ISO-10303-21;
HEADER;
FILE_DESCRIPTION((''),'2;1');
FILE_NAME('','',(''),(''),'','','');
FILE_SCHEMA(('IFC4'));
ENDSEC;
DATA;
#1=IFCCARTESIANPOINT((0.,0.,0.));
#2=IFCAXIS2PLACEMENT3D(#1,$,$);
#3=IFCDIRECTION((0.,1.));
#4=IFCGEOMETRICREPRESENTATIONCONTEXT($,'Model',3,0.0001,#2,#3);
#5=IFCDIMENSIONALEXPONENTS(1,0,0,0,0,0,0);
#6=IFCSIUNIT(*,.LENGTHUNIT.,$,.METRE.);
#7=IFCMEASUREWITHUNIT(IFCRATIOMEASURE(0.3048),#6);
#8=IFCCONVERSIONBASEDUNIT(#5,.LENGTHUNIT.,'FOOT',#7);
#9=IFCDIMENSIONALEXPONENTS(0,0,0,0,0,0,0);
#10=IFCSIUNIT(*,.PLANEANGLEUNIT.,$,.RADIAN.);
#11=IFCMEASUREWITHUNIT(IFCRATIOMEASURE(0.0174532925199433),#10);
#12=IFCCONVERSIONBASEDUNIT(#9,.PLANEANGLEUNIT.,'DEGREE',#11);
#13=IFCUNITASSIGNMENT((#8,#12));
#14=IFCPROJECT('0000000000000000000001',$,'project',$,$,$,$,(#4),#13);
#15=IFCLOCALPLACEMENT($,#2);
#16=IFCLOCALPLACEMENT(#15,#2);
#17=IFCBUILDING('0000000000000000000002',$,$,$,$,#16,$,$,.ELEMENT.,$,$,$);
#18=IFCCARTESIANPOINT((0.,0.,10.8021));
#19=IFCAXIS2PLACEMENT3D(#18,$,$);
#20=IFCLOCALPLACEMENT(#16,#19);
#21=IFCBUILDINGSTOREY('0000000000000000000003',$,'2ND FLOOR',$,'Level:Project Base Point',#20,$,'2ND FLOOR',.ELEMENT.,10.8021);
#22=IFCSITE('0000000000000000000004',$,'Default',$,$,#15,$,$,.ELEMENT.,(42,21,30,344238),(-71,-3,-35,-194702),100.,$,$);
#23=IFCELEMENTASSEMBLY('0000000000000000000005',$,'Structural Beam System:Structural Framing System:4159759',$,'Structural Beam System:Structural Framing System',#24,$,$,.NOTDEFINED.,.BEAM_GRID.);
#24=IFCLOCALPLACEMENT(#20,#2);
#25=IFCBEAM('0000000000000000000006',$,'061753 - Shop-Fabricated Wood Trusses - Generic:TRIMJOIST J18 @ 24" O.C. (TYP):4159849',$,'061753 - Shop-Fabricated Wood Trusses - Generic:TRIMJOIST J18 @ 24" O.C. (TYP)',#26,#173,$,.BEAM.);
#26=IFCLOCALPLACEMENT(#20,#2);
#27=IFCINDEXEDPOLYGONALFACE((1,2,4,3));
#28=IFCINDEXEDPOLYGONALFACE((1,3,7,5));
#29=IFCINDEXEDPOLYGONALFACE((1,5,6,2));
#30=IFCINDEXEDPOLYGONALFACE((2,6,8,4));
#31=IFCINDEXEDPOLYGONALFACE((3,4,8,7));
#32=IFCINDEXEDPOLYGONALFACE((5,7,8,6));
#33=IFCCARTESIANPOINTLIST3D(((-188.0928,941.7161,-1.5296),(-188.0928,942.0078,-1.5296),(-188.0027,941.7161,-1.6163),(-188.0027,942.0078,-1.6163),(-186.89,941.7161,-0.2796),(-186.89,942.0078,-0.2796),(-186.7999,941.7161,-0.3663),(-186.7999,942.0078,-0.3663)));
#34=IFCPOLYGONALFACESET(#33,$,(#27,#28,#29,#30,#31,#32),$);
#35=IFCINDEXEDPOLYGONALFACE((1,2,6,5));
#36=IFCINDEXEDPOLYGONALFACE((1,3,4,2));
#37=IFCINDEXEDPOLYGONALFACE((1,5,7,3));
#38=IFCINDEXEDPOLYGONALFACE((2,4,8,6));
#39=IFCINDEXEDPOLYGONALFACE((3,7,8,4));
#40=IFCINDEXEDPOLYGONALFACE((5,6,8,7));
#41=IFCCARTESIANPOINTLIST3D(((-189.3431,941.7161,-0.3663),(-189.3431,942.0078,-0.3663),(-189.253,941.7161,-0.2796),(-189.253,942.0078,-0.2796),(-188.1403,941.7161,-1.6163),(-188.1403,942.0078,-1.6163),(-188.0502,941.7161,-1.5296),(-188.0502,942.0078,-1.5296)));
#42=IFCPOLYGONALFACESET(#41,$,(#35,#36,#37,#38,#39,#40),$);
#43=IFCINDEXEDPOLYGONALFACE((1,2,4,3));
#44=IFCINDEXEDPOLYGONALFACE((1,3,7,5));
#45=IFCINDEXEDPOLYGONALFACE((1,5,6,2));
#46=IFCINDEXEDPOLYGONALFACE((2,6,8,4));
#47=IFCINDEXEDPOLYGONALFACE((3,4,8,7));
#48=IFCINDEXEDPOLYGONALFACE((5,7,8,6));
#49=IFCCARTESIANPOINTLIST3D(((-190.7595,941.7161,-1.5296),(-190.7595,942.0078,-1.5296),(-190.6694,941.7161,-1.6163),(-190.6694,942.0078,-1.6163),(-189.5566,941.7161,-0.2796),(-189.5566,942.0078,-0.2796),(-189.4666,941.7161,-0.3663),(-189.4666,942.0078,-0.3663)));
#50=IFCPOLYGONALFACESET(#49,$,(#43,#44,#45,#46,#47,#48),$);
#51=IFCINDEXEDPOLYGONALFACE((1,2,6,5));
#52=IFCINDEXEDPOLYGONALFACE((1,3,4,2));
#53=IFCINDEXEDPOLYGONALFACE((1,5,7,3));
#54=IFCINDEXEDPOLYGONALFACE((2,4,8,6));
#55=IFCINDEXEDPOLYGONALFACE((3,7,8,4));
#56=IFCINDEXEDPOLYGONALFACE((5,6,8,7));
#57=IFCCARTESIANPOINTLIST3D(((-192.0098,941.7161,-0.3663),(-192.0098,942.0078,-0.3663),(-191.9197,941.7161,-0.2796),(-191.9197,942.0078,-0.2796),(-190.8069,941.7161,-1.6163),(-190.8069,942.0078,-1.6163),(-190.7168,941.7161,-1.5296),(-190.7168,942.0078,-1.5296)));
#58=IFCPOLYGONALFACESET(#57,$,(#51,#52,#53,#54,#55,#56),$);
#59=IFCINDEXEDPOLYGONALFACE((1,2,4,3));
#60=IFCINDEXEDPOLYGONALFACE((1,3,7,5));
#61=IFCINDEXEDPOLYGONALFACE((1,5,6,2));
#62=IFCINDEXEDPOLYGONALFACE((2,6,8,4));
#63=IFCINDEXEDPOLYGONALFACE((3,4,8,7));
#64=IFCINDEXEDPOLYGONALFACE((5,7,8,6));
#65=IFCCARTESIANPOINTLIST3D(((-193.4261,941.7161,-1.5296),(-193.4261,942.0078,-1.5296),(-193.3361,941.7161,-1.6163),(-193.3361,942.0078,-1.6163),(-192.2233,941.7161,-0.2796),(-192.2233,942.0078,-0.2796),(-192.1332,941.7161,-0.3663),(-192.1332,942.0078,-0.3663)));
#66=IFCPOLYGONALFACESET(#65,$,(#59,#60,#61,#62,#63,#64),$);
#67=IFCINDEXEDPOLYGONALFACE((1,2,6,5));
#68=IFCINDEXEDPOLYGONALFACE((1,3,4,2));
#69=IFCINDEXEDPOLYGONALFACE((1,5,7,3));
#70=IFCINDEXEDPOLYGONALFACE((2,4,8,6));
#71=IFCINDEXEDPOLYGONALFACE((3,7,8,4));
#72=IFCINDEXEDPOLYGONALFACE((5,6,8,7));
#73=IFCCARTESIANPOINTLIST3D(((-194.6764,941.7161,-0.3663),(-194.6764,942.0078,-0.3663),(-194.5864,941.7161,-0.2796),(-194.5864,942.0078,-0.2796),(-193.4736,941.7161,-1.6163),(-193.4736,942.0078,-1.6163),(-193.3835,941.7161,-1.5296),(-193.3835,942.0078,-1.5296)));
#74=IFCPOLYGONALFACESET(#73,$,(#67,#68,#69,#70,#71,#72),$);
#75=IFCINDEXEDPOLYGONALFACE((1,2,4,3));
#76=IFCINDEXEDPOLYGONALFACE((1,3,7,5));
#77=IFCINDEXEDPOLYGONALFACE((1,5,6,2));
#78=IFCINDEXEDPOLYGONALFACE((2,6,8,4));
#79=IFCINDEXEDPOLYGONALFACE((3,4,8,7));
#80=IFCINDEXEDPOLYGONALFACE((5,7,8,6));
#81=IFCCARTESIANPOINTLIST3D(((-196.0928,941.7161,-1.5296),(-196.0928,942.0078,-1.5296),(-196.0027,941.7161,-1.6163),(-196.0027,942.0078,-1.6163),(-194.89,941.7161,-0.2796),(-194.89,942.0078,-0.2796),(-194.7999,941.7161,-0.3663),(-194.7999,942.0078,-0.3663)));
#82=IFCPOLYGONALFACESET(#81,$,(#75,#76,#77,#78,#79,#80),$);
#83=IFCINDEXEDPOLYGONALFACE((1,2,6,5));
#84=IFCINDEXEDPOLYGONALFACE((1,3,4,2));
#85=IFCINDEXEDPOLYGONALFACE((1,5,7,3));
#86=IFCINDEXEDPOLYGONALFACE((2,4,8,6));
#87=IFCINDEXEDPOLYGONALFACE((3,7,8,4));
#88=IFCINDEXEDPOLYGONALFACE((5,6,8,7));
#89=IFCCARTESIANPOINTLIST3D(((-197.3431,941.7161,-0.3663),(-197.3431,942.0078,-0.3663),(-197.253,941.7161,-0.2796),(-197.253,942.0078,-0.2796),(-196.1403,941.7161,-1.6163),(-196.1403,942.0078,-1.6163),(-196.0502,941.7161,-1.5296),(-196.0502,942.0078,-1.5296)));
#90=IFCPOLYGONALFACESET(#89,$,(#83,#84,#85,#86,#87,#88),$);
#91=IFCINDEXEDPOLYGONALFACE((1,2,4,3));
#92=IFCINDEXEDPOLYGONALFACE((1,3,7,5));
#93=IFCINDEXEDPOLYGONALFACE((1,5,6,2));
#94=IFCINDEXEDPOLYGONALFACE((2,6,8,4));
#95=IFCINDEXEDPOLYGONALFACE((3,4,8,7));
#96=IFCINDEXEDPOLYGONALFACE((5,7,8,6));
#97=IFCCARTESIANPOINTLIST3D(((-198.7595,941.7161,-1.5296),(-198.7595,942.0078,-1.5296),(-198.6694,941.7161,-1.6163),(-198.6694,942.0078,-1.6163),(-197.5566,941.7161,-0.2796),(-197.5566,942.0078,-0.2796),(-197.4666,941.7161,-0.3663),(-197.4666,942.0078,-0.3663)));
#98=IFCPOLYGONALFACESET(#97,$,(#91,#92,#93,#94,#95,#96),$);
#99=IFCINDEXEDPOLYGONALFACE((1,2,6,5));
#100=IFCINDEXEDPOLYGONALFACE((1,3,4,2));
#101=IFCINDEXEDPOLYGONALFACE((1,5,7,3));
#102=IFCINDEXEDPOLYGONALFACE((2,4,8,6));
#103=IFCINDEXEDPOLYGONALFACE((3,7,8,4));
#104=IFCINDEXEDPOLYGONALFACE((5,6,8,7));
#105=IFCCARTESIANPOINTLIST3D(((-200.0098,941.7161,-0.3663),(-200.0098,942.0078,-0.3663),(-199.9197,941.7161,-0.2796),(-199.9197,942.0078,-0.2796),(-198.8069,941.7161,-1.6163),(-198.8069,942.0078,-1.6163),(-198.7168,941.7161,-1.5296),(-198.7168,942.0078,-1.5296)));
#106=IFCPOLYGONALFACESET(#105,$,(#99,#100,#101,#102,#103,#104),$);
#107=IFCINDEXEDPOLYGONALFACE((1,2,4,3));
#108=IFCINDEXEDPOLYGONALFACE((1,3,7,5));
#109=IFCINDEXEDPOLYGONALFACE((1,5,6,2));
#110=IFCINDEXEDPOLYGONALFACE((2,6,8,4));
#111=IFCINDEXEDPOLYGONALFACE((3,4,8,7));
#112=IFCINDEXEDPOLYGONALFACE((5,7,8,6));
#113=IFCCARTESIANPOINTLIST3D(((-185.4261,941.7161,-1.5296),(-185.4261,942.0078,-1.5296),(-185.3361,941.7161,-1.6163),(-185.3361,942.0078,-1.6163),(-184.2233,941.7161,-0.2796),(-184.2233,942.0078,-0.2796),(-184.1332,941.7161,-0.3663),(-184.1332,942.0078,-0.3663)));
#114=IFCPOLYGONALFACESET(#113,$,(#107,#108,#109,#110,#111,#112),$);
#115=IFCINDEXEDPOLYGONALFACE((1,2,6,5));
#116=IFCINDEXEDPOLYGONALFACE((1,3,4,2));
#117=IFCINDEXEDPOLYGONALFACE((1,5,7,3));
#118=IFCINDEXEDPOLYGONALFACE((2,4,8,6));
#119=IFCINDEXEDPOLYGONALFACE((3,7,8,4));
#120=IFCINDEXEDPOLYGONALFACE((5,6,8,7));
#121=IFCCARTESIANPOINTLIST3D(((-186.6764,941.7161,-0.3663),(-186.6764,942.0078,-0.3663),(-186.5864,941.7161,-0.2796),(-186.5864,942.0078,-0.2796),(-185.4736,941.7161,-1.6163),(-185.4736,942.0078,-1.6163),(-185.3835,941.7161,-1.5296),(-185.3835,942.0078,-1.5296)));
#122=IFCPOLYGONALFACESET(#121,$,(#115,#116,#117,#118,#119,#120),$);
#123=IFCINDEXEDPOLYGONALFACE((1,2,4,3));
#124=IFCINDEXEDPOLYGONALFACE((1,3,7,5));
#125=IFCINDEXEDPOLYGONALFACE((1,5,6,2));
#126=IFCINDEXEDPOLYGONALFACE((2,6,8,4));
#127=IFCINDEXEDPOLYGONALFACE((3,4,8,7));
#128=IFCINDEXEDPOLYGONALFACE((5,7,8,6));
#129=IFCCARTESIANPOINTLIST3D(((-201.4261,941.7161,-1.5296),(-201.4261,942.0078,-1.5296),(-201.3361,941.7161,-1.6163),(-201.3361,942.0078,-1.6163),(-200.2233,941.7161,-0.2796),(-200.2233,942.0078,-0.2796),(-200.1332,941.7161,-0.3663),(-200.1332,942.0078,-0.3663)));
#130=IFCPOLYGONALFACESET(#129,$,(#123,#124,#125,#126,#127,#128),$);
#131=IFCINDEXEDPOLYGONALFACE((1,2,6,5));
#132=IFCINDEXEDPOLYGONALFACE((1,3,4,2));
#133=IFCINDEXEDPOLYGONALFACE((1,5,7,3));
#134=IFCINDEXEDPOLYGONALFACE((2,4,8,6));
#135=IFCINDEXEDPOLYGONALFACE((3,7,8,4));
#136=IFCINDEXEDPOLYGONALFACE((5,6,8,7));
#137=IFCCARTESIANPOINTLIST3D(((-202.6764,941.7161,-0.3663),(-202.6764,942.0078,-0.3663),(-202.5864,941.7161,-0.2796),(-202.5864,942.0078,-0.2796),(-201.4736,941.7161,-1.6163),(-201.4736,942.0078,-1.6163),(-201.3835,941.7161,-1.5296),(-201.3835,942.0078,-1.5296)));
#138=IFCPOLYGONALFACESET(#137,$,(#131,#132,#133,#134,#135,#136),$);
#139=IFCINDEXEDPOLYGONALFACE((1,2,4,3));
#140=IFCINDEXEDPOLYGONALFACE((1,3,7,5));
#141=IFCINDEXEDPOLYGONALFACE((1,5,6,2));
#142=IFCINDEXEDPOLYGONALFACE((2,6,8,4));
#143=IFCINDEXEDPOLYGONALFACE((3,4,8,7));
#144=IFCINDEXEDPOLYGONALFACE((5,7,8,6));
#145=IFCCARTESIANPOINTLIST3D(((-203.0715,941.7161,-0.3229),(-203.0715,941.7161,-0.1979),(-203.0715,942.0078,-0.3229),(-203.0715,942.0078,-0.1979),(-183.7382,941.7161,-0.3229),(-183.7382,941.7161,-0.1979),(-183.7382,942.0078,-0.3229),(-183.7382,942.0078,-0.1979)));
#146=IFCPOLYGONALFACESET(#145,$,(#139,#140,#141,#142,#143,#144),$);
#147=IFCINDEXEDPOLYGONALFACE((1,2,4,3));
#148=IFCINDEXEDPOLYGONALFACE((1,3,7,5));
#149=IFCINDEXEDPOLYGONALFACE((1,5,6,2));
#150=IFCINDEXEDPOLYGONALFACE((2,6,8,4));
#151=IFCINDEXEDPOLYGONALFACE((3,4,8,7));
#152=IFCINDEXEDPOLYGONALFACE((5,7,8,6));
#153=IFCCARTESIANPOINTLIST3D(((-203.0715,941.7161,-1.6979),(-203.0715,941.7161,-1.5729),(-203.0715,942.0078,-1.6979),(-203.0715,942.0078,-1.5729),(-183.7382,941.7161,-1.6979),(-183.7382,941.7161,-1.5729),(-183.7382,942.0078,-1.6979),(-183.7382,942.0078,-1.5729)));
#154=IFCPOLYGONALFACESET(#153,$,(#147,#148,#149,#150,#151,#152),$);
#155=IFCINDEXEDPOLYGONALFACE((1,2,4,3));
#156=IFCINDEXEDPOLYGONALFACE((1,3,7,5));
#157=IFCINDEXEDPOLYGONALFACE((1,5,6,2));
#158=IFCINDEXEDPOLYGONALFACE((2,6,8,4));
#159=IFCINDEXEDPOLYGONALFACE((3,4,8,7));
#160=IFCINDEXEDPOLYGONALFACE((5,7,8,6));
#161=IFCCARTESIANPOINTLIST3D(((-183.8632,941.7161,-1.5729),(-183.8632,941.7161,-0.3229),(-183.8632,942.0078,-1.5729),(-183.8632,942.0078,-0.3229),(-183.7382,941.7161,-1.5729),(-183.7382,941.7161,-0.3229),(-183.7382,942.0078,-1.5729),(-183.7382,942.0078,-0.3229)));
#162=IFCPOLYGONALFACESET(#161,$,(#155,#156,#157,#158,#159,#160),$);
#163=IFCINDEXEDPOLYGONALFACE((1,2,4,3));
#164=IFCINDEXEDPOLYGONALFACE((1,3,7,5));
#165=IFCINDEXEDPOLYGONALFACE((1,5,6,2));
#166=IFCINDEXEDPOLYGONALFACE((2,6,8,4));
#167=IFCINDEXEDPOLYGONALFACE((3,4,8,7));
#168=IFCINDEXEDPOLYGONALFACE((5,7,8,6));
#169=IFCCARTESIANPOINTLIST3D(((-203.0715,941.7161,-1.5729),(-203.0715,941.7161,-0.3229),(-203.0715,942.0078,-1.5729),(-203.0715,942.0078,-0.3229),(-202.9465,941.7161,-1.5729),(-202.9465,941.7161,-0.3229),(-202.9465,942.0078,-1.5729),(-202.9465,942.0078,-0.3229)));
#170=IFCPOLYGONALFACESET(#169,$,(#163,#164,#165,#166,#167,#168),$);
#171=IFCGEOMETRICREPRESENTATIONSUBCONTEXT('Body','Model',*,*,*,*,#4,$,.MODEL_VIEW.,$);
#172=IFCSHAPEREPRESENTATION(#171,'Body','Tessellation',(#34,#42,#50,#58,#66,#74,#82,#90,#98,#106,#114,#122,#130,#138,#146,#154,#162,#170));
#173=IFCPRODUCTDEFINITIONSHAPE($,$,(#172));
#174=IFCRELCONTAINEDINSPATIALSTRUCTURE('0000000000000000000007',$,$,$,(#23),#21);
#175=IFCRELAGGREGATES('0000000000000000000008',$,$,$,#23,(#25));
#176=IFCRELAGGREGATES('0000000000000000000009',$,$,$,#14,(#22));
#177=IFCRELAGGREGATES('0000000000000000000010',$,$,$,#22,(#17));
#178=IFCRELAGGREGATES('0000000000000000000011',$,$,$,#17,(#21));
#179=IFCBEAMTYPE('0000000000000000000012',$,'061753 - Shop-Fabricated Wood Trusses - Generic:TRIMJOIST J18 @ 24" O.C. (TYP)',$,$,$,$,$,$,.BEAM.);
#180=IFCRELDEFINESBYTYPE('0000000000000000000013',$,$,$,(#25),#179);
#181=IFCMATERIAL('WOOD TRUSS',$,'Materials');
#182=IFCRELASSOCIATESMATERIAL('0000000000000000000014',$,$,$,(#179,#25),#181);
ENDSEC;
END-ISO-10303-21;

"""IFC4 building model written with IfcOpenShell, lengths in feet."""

from ifc_helpers import new_model, entity, si_unit, converted_unit, direction, frame, frame_2d, origin, origin_2d_with_axis, place, context, subcontext, project, spatial, rectangle, extrude, source, transform, mapped, material, material_profile, profile_set, profile_usage, type_object, type_shapes, element, aggregate, save


model = new_model("IFC4")

# Units and contexts
model_context = context("Model", 3, precision=0.0001, world=origin(), true_north=direction((0.0, 1.0)))
body_context = subcontext(model_context, "Body", "Model", "MODEL_VIEW")
ifc_project = project(units=[converted_unit("LENGTHUNIT", "FOOT", entity("IfcRatioMeasure", 0.3048), si_unit("LENGTHUNIT", "METRE"), dimensions=[1, 0, 0, 0, 0, 0, 0]), converted_unit("PLANEANGLEUNIT", "DEGREE", entity("IfcRatioMeasure", 0.0174532925199433), si_unit("PLANEANGLEUNIT", "RADIAN"), dimensions=[0, 0, 0, 0, 0, 0, 0])], contexts=[model_context])

# Site, building, storey
site_placement = place(None, origin())
site = spatial("IfcSite", under=ifc_project, at=site_placement, Name="Default", CompositionType="ELEMENT", RefLatitude=(42, 21, 30, 344238), RefLongitude=(-71, -3, -35, -194702), RefElevation=100.0)
building_placement = place(site_placement, origin())
building = spatial("IfcBuilding", under=site, at=building_placement, CompositionType="ELEMENT")
storey_placement = place(building_placement, frame((0.0, 0.0, 10.8021)))
storey = spatial("IfcBuildingStorey", under=building, at=storey_placement, Name="2ND FLOOR", ObjectType="Level:Project Base Point", LongName="2ND FLOOR", CompositionType="ELEMENT", Elevation=10.8021)

# Element assembly, beam
ifc_material_1 = material(Name="WOOD TRUSS", Category="Materials")
ifc_material_profile_1 = material_profile(ifc_material_1, rectangle(XDim=1.7347, YDim=0.125, at=frame_2d((0.0, 0.0), x_axis=(1.0, 0.0))), Name="TRIMJOIST J18 @ 24\" O.C. (TYP)")
ifc_material_profile_2 = material_profile(ifc_material_1, rectangle(XDim=1.7347, YDim=0.125, at=frame_2d((0.0, 0.0), x_axis=(1.0, 0.0))), Name="TRIMJOIST J18 @ 24\" O.C. (TYP)")
ifc_material_profile_3 = material_profile(ifc_material_1, rectangle(XDim=1.7347, YDim=0.125, at=frame_2d((0.0, 0.0), x_axis=(1.0, 0.0))), Name="TRIMJOIST J18 @ 24\" O.C. (TYP)")
ifc_material_profile_4 = material_profile(ifc_material_1, rectangle(XDim=1.7347, YDim=0.125, at=frame_2d((0.0, 0.0), x_axis=(1.0, 0.0))), Name="TRIMJOIST J18 @ 24\" O.C. (TYP)")
ifc_material_profile_5 = material_profile(ifc_material_1, rectangle(XDim=1.7347, YDim=0.125, at=frame_2d((0.0, 0.0), x_axis=(1.0, 0.0))), Name="TRIMJOIST J18 @ 24\" O.C. (TYP)")
ifc_material_profile_6 = material_profile(ifc_material_1, rectangle(XDim=1.7347, YDim=0.125, at=frame_2d((0.0, 0.0), x_axis=(1.0, 0.0))), Name="TRIMJOIST J18 @ 24\" O.C. (TYP)")
ifc_material_profile_7 = material_profile(ifc_material_1, rectangle(XDim=1.7347, YDim=0.125, at=frame_2d((0.0, 0.0), x_axis=(1.0, 0.0))), Name="TRIMJOIST J18 @ 24\" O.C. (TYP)")
ifc_material_profile_8 = material_profile(ifc_material_1, rectangle(XDim=1.7347, YDim=0.125, at=frame_2d((0.0, 0.0), x_axis=(1.0, 0.0))), Name="TRIMJOIST J18 @ 24\" O.C. (TYP)")
ifc_material_profile_9 = material_profile(ifc_material_1, rectangle(XDim=1.7347, YDim=0.125, at=frame_2d((0.0, 0.0), x_axis=(1.0, 0.0))), Name="TRIMJOIST J18 @ 24\" O.C. (TYP)")
ifc_material_profile_10 = material_profile(ifc_material_1, rectangle(XDim=1.7347, YDim=0.125, at=origin_2d_with_axis()), Name="TRIMJOIST J18 @ 24\" O.C. (TYP)")
ifc_material_profile_11 = material_profile(ifc_material_1, rectangle(XDim=0.125, YDim=0.2917, at=origin_2d_with_axis()), Name="TRIMJOIST J18 @ 24\" O.C. (TYP)")
ifc_material_profile_12 = material_profile(ifc_material_1, rectangle(XDim=0.125, YDim=0.2917, at=origin_2d_with_axis()), Name="TRIMJOIST J18 @ 24\" O.C. (TYP)")
ifc_material_profile_13 = material_profile(ifc_material_1, rectangle(XDim=1.25, YDim=0.2917, at=origin_2d_with_axis()), Name="TRIMJOIST J18 @ 24\" O.C. (TYP)")
ifc_material_profile_14 = material_profile(ifc_material_1, rectangle(XDim=1.25, YDim=0.2917, at=origin_2d_with_axis()), Name="TRIMJOIST J18 @ 24\" O.C. (TYP)")
ifc_profile_set_1 = profile_set([ifc_material_profile_1, ifc_material_profile_2, ifc_material_profile_3, ifc_material_profile_4, ifc_material_profile_5, ifc_material_profile_6, ifc_material_profile_7, ifc_material_profile_8, ifc_material_profile_9, ifc_material_profile_10, ifc_material_profile_11, ifc_material_profile_12, ifc_material_profile_13, ifc_material_profile_14], Name="TRIMJOIST J18 @ 24\" O.C. (TYP)")
beam_type_1 = type_object("IfcBeamType", Name="061753 - Shop-Fabricated Wood Trusses - Generic:TRIMJOIST J18 @ 24\" O.C. (TYP)", PredefinedType="BEAM", material=ifc_profile_set_1)
shared_shape_1 = source(origin(), body_context, "Body", "SweptSolid", [
    extrude(rectangle(XDim=1.7347, YDim=0.125, at=frame_2d((0.0, 0.0), x_axis=(1.0, 0.0))), frame((5.9585, -0.1458, 0.0), z_axis=(0.0, 1.0, 0.0), x_axis=(0.693383, 0.0, 0.720569)), (0.0, 0.0, 1.0), 0.2917),
    extrude(rectangle(XDim=1.7347, YDim=0.125, at=origin_2d_with_axis()), frame((4.7082, -0.1458, 0.0), z_axis=(0.0, 1.0, 0.0), x_axis=(0.693383, 0.0, -0.720569)), (0.0, 0.0, 1.0), 0.2917),
    extrude(rectangle(XDim=1.7347, YDim=0.125, at=frame_2d((0.0, 0.0), x_axis=(1.0, 0.0))), frame((3.2918, -0.1458, 0.0), z_axis=(0.0, 1.0, 0.0), x_axis=(0.693383, 0.0, 0.720569)), (0.0, 0.0, 1.0), 0.2917),
    extrude(rectangle(XDim=1.7347, YDim=0.125, at=frame_2d((0.0, 0.0), x_axis=(1.0, 0.0))), frame((2.0415, -0.1458, 0.0), z_axis=(0.0, 1.0, 0.0), x_axis=(0.693383, 0.0, -0.720569)), (0.0, 0.0, 1.0), 0.2917),
    extrude(rectangle(XDim=1.7347, YDim=0.125, at=frame_2d((0.0, 0.0), x_axis=(1.0, 0.0))), frame((0.6251, -0.1458, 0.0), z_axis=(0.0, 1.0, 0.0), x_axis=(0.693383, 0.0, 0.720569)), (0.0, 0.0, 1.0), 0.2917),
    extrude(rectangle(XDim=1.7347, YDim=0.125, at=frame_2d((0.0, 0.0), x_axis=(1.0, 0.0))), frame((-0.6251, -0.1458, 0.0), z_axis=(0.0, 1.0, 0.0), x_axis=(0.693383, 0.0, -0.720569)), (0.0, 0.0, 1.0), 0.2917),
    extrude(rectangle(XDim=1.7347, YDim=0.125, at=frame_2d((0.0, 0.0), x_axis=(1.0, 0.0))), frame((-2.0415, -0.1458, 0.0), z_axis=(0.0, 1.0, 0.0), x_axis=(0.693383, 0.0, 0.720569)), (0.0, 0.0, 1.0), 0.2917),
    extrude(rectangle(XDim=1.7347, YDim=0.125, at=origin_2d_with_axis()), frame((-3.2918, -0.1458, 0.0), z_axis=(0.0, 1.0, 0.0), x_axis=(0.693383, 0.0, -0.720569)), (0.0, 0.0, 1.0), 0.2917),
    extrude(rectangle(XDim=1.7347, YDim=0.125, at=frame_2d((0.0, 0.0), x_axis=(1.0, 0.0))), frame((-4.7082, -0.1458, 0.0), z_axis=(0.0, 1.0, 0.0), x_axis=(0.693383, 0.0, 0.720569)), (0.0, 0.0, 1.0), 0.2917),
    extrude(rectangle(XDim=1.7347, YDim=0.125, at=frame_2d((0.0, 0.0), x_axis=(1.0, 0.0))), frame((-5.9585, -0.1458, 0.0), z_axis=(0.0, 1.0, 0.0), x_axis=(0.693383, 0.0, -0.720569)), (0.0, 0.0, 1.0), 0.2917),
    extrude(rectangle(XDim=1.7347, YDim=0.125, at=frame_2d((0.0, 0.0), x_axis=(1.0, 0.0))), frame((8.6251, -0.1458, 0.0), z_axis=(0.0, 1.0, 0.0), x_axis=(0.693383, 0.0, 0.720569)), (0.0, 0.0, 1.0), 0.2917),
    extrude(rectangle(XDim=1.7347, YDim=0.125, at=origin_2d_with_axis()), frame((7.3749, -0.1458, 0.0), z_axis=(0.0, 1.0, 0.0), x_axis=(0.693383, 0.0, -0.720569)), (0.0, 0.0, 1.0), 0.2917),
    extrude(rectangle(XDim=1.7347, YDim=0.125, at=frame_2d((0.0, 0.0), x_axis=(1.0, 0.0))), frame((-7.3749, -0.1458, 0.0), z_axis=(0.0, 1.0, 0.0), x_axis=(0.693383, 0.0, 0.720569)), (0.0, 0.0, 1.0), 0.2917),
    extrude(rectangle(XDim=1.7347, YDim=0.125, at=origin_2d_with_axis()), frame((-8.6251, -0.1458, 0.0), z_axis=(0.0, 1.0, 0.0), x_axis=(0.693383, 0.0, -0.720569)), (0.0, 0.0, 1.0), 0.2917),
    extrude(rectangle(XDim=0.125, YDim=0.2917, at=origin_2d_with_axis()), frame((-9.6667, 0.0, 0.6875), z_axis=(1.0, 0.0, 0.0), x_axis=(0.0, 0.0, -1.0)), (0.0, 0.0, 1.0), 19.3333),
    extrude(rectangle(XDim=0.125, YDim=0.2917, at=origin_2d_with_axis()), frame((-9.6667, 0.0, -0.6875), z_axis=(1.0, 0.0, 0.0), x_axis=(0.0, 0.0, -1.0)), (0.0, 0.0, 1.0), 19.3333),
    extrude(rectangle(XDim=1.25, YDim=0.2917, at=origin_2d_with_axis()), frame((9.5417, 0.0, 0.0), z_axis=(1.0, 0.0, 0.0), x_axis=(0.0, 0.0, -1.0)), (0.0, 0.0, 1.0), 0.125),
    extrude(rectangle(XDim=1.25, YDim=0.2917, at=origin_2d_with_axis()), frame((-9.6667, 0.0, 0.0), z_axis=(1.0, 0.0, 0.0), x_axis=(0.0, 0.0, -1.0)), (0.0, 0.0, 1.0), 0.125),
])
type_shapes(beam_type_1, [shared_shape_1])
assembly_1_placement = place(storey_placement, origin())
assembly_1 = element("IfcElementAssembly", 1, at=assembly_1_placement, inside=storey, Name="Structural Beam System:Structural Framing System:4159759", ObjectType="Structural Beam System:Structural Framing System", AssemblyPlace="NOTDEFINED", PredefinedType="BEAM_GRID")
ifc_profile_usage_1 = profile_usage(ifc_profile_set_1, cardinal=8)
beam_1_placement = place(assembly_1_placement, frame((-193.4048, 941.8619, -0.9479)))
beam_1 = element("IfcBeam", 2, at=beam_1_placement, type_object=beam_type_1, material=ifc_profile_usage_1, Name="061753 - Shop-Fabricated Wood Trusses - Generic:TRIMJOIST J18 @ 24\" O.C. (TYP):4159849", ObjectType="061753 - Shop-Fabricated Wood Trusses - Generic:TRIMJOIST J18 @ 24\" O.C. (TYP)", PredefinedType="BEAM", context=body_context, shape_type="MappedRepresentation", body=[
    mapped(shared_shape_1, transform((0.0, 0.0, 0.0), scale=1.0)),
])

aggregate(assembly_1, [beam_1])

save(model, "model.ifc")
